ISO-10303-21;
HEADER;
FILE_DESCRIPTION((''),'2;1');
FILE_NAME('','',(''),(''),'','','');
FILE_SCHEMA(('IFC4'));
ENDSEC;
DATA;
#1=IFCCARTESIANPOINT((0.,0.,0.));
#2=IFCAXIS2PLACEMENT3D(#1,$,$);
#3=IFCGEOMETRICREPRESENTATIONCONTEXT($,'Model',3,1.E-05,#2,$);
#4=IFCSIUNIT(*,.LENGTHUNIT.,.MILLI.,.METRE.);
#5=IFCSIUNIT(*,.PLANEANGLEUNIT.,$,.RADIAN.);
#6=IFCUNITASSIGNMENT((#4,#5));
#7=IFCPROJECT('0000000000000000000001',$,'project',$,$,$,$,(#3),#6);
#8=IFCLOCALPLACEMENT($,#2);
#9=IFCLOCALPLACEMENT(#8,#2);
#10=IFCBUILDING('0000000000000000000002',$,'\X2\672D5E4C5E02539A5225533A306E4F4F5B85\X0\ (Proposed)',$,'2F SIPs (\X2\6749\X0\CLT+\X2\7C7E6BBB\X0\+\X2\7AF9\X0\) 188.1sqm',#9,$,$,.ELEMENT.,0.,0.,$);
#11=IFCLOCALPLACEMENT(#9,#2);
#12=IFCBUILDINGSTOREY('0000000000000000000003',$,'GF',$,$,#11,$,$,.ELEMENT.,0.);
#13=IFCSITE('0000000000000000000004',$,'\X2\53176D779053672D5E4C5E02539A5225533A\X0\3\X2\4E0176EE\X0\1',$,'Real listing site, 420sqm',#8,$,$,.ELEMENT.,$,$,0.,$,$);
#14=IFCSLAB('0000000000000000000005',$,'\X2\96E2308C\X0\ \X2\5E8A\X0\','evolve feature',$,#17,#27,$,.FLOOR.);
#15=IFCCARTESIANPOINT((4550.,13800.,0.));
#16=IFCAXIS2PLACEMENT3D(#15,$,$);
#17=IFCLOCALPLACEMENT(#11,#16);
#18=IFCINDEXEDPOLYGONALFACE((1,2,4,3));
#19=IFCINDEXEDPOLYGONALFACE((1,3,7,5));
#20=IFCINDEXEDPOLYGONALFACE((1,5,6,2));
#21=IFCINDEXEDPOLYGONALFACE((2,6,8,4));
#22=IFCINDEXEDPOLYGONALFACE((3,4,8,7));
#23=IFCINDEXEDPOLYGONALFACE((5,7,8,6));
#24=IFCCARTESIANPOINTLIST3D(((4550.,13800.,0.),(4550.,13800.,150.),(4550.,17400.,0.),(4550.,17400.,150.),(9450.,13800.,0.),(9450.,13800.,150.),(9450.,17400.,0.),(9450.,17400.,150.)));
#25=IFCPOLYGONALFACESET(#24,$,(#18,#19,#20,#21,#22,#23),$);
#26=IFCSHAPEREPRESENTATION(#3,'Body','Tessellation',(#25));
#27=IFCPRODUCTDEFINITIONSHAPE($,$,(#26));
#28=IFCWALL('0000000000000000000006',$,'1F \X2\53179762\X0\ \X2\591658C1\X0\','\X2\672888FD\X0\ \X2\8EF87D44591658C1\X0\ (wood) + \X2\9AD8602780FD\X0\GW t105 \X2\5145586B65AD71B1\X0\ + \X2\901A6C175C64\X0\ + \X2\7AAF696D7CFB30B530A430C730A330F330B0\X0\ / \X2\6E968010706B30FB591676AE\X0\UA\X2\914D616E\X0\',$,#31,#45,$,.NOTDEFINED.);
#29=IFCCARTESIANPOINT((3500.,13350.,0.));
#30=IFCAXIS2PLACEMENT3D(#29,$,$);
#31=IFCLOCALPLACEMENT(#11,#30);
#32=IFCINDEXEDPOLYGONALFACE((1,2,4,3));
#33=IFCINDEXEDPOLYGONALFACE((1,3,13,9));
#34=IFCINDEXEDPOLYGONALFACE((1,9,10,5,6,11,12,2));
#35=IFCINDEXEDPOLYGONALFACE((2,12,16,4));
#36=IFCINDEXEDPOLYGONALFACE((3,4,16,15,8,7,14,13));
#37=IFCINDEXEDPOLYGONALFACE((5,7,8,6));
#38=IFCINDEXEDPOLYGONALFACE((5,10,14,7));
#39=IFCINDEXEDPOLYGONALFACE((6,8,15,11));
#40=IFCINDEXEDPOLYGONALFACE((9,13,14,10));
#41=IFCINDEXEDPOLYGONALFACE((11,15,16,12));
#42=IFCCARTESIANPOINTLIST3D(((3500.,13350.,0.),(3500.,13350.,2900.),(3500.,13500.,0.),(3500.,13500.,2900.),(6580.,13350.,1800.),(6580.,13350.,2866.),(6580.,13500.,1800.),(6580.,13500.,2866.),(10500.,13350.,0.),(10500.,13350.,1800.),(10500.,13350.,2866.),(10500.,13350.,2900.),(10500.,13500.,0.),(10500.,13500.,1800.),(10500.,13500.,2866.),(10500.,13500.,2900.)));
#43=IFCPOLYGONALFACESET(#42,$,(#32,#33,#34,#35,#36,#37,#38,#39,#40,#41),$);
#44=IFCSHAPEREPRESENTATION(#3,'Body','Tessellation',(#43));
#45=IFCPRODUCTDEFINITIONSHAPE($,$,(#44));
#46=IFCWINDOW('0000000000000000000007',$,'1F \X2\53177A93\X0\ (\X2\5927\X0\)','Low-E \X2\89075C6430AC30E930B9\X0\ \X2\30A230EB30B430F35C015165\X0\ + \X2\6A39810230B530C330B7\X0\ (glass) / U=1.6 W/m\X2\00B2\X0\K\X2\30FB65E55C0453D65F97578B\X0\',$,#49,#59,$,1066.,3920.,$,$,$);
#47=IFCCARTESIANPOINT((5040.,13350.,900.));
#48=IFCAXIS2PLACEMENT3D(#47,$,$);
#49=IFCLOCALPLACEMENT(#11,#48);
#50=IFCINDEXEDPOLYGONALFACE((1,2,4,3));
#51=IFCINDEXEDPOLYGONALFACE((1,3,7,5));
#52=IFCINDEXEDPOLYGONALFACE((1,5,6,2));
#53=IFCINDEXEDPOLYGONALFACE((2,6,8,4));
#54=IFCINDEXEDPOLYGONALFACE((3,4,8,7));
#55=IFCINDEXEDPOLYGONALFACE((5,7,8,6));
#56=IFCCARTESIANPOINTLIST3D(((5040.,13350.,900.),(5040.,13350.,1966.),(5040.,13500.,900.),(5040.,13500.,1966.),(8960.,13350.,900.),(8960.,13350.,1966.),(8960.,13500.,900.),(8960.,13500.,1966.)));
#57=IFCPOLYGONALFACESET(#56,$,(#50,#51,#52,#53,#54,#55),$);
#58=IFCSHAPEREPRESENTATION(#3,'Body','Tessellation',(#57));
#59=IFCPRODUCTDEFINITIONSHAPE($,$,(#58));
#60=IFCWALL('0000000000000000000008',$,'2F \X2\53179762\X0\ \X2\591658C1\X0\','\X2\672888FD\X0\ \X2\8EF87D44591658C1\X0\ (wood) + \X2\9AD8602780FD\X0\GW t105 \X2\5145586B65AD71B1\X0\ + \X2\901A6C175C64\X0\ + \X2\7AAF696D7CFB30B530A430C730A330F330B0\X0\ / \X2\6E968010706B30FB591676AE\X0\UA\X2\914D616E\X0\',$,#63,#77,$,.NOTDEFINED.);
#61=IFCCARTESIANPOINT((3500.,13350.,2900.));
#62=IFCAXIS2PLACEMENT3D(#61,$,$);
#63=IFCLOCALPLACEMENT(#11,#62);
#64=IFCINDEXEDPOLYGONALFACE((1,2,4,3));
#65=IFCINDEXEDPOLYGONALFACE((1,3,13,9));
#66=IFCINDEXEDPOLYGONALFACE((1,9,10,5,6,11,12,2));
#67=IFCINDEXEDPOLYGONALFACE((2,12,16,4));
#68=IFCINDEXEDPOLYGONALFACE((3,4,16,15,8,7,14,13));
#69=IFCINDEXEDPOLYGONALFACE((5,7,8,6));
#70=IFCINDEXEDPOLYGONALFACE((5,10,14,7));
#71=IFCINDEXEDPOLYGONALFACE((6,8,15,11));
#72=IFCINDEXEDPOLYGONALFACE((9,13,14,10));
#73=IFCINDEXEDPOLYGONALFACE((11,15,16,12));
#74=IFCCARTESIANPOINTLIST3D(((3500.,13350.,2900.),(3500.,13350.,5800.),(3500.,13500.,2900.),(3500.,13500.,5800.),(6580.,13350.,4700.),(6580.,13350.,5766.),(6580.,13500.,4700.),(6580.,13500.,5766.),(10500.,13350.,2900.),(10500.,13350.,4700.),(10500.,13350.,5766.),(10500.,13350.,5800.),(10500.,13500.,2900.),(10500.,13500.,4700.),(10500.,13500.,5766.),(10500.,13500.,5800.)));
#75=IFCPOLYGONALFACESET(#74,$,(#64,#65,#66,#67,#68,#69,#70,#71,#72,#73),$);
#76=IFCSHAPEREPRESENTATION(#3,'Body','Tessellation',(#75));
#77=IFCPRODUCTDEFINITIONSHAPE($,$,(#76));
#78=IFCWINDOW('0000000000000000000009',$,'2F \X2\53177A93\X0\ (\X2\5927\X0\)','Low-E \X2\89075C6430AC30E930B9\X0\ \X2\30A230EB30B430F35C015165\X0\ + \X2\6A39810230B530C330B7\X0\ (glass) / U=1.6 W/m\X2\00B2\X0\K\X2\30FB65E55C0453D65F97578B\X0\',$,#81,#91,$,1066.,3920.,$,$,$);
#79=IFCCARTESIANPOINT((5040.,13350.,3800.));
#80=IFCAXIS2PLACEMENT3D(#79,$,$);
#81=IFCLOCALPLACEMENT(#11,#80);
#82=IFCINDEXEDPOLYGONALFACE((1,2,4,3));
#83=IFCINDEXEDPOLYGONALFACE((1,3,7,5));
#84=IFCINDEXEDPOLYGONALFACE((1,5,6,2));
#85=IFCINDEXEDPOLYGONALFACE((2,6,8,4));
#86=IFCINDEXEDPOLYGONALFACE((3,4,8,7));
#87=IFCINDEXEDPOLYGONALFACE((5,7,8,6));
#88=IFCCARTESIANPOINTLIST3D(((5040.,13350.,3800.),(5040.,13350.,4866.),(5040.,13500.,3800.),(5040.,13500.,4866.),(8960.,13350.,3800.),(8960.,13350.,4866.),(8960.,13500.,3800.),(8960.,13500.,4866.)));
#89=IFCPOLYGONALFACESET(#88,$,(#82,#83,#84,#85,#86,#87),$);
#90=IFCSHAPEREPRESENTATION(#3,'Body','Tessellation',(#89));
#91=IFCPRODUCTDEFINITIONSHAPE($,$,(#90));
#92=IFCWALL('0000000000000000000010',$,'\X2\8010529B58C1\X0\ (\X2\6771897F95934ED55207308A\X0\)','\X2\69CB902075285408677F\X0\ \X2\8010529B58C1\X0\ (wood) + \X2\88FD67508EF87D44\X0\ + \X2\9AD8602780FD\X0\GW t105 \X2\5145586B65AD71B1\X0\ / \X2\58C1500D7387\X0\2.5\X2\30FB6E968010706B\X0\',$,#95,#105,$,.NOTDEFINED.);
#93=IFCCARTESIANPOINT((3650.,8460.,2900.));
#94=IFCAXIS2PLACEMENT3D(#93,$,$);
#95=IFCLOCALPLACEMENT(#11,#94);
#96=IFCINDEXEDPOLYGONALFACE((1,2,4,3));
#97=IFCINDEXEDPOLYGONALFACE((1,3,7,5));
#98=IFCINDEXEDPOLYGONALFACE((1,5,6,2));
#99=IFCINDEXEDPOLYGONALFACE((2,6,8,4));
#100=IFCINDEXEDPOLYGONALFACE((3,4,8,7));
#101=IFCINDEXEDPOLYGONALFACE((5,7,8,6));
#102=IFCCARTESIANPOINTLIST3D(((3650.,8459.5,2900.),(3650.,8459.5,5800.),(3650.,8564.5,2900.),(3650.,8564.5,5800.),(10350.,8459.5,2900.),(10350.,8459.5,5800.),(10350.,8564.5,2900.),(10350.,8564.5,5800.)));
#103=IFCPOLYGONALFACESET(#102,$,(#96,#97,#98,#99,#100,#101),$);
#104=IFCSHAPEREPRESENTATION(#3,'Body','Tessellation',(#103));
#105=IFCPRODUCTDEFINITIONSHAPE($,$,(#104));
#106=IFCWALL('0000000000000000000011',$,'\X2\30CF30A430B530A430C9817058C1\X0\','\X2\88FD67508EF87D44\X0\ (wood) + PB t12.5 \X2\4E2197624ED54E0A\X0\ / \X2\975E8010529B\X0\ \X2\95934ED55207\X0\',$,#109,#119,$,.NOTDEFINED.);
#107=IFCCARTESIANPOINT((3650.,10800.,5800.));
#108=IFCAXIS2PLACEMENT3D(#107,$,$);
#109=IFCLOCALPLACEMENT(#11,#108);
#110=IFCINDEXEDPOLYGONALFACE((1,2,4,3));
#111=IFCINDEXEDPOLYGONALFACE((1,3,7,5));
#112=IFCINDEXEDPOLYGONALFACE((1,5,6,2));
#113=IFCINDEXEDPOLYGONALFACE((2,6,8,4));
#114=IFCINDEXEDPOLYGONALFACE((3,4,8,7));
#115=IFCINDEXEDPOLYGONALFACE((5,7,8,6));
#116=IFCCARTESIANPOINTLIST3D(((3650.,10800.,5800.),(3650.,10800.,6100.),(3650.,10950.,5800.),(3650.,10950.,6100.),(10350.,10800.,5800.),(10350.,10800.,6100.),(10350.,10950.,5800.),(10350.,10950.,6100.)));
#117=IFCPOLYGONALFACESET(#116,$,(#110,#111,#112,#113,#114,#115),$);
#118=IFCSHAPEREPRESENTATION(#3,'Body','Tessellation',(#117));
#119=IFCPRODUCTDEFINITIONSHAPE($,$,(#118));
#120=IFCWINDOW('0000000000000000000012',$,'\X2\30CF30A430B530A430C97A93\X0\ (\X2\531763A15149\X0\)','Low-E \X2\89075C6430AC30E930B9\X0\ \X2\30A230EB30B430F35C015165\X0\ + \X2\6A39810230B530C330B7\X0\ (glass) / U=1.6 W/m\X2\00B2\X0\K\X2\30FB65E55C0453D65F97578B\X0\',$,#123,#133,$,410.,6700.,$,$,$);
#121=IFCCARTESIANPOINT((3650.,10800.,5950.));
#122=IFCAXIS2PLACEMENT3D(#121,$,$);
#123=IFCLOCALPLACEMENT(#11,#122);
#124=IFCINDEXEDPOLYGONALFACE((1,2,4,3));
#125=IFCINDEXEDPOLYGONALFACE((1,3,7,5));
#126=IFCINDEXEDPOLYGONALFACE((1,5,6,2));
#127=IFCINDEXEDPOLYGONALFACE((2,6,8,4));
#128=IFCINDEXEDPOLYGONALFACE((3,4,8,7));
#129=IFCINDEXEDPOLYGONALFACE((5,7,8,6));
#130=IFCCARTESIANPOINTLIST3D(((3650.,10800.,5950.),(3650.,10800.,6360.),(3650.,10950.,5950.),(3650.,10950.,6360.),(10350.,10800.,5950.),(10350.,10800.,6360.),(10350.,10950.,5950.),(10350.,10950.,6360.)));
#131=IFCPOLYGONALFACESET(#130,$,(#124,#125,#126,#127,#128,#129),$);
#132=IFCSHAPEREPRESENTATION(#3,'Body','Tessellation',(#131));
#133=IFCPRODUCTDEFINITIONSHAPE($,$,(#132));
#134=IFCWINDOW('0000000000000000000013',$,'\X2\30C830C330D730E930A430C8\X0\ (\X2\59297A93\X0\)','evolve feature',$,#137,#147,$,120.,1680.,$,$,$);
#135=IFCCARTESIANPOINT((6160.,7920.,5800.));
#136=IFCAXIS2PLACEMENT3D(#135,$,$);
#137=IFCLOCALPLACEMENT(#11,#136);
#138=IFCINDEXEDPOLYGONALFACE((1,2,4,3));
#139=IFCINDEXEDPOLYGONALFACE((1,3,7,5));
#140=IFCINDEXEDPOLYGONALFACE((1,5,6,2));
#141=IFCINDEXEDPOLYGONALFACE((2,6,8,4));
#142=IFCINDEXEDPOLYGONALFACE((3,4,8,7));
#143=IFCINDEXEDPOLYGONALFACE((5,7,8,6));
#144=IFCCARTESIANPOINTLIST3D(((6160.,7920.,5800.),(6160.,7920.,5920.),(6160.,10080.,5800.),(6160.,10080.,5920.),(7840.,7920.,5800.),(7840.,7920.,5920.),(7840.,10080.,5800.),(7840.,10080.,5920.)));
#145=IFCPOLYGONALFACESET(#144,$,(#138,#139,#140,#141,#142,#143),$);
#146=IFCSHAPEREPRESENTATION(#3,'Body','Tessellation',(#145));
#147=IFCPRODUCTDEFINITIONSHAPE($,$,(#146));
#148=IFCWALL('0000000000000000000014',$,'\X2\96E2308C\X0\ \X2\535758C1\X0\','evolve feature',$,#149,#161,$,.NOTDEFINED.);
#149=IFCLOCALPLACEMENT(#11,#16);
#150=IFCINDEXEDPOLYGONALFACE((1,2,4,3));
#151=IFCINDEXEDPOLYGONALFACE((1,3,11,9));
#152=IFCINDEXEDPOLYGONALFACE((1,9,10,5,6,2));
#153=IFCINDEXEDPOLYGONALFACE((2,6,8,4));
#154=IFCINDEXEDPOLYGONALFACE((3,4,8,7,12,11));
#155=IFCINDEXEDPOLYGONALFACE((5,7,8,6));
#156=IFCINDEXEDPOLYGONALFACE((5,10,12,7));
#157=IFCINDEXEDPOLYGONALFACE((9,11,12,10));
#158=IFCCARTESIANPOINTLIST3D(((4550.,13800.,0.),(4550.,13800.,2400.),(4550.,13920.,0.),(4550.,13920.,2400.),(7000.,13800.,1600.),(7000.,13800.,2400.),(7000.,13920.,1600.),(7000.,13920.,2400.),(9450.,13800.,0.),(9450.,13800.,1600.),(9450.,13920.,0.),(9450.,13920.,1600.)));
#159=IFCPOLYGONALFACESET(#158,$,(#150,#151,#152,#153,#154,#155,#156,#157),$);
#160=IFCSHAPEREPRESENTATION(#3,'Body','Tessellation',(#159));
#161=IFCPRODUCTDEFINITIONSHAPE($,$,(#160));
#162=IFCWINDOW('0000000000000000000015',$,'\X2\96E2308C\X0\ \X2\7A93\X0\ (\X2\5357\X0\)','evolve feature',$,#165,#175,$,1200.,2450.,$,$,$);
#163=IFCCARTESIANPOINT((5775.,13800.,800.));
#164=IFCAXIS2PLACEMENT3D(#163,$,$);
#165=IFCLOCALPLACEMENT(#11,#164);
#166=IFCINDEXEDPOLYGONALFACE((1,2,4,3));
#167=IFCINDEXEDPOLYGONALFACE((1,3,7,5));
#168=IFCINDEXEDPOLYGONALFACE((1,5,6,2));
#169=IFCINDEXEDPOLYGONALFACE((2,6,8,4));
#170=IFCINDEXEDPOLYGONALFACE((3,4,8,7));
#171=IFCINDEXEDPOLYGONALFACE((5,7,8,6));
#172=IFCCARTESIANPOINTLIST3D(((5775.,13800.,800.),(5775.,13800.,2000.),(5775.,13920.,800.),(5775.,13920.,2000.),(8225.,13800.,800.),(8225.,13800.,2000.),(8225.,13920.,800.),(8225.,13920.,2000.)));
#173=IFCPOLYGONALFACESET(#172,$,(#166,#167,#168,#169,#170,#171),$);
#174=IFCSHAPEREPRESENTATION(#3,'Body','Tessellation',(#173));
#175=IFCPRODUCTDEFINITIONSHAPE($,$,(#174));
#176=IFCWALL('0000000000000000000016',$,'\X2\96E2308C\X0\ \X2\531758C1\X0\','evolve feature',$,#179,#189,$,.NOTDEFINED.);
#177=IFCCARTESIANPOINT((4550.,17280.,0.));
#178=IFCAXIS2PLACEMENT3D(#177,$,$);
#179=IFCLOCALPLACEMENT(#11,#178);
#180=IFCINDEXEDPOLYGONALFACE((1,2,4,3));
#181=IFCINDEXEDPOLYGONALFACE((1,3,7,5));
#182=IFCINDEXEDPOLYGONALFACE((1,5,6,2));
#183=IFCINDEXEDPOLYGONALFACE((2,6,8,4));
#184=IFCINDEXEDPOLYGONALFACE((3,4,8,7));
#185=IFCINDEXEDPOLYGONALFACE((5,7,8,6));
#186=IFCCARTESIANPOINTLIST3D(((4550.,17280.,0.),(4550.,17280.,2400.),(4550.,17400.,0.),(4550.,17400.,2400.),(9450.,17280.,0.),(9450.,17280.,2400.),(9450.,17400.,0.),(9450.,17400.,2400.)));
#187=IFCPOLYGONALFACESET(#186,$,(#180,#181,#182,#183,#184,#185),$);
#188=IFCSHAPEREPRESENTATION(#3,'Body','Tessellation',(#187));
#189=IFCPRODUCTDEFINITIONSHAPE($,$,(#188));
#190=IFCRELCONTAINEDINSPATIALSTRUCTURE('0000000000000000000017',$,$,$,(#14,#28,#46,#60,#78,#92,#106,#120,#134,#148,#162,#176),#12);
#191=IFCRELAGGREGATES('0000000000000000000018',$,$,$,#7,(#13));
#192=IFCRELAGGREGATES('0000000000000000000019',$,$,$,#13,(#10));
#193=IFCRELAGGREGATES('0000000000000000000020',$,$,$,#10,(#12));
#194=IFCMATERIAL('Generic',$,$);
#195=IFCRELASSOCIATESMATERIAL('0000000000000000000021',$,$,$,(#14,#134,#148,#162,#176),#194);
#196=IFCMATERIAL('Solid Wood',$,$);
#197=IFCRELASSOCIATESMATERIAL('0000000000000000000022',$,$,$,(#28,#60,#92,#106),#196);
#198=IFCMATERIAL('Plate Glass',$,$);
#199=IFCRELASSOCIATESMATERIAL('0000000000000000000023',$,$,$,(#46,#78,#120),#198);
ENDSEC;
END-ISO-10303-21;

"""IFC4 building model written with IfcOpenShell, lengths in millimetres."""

from ifc_helpers import new_model, si_unit, frame, frame_2d, origin, place, context, project, spatial, rectangle, extrude, material, element, fill, save


model = new_model("IFC4")

# Units and contexts
model_context = context("Model", 3, precision=1e-05, world=origin())
ifc_project = project(units=[si_unit("LENGTHUNIT", "METRE", prefix="MILLI"), si_unit("PLANEANGLEUNIT", "RADIAN")], contexts=[model_context])

# Site, building, storey
site_placement = place(None, origin())
site = spatial("IfcSite", under=ifc_project, at=site_placement, Name="北海道札幌市厚別区3丁目1", ObjectType="Real listing site, 420sqm", CompositionType="ELEMENT", RefElevation=0.0)
building_placement = place(site_placement, origin())
building = spatial("IfcBuilding", under=site, at=building_placement, Name="札幌市厚別区の住宅 (Proposed)", ObjectType="2F SIPs (杉CLT+籾殻+竹) 188.1sqm", CompositionType="ELEMENT", ElevationOfRefHeight=0.0, ElevationOfTerrain=0.0)
storey_placement = place(building_placement, origin())
storey = spatial("IfcBuildingStorey", under=building, at=storey_placement, Name="GF", CompositionType="ELEMENT", Elevation=0.0)

# Slab
ifc_material_1 = material(Name="Generic")
slab_placement = place(storey_placement, frame((4550.0, 13800.0, 0.0)))
element("IfcSlab", 1, at=slab_placement, inside=storey, material=ifc_material_1, Name="離れ 床", Description="evolve feature", PredefinedType="FLOOR", context=model_context, shape_type="SweptSolid", body=[
    extrude(rectangle(XDim=4900.0, YDim=3600.0, at=frame_2d((2450.0, 1800.0))), frame((4550.0, 13800.0, 0.0)), (0.0, 0.0, 1.0), 150.0),
])

# Wall, opening, window
ifc_material_2 = material(Name="Solid Wood")
wall_1_placement = place(storey_placement, frame((3500.0, 13350.0, 0.0)))
wall_1 = element("IfcWall", 2, at=wall_1_placement, inside=storey, material=ifc_material_2, Name="1F 北面 外壁", Description="木製 軸組外壁 (wood) + 高性能GW t105 充填断熱 + 通気層 + 窯業系サイディング / 準耐火・外皮UA配慮", PredefinedType="NOTDEFINED", context=model_context, shape_type="SweptSolid", body=[
    extrude(rectangle(XDim=7000.0, YDim=150.0, at=frame_2d((3500.0, 75.0))), frame((3500.0, 13350.0, 0.0)), (0.0, 0.0, 1.0), 2900.0),
])
opening_1_placement = place(storey_placement, frame((5040.0, 13350.0, 900.0)))
opening_1 = element("IfcOpeningElement", 3, at=opening_1_placement, cuts=wall_1, PredefinedType="NOTDEFINED", context=model_context, shape_type="SweptSolid", body=[
    extrude(rectangle(XDim=3920.0, YDim=150.0, at=frame_2d((1960.0, 75.0))), frame((5040.0, 13350.0, 900.0)), (0.0, 0.0, 1.0), 1066.0),
])
ifc_material_3 = material(Name="Plate Glass")
window_1_placement = place(storey_placement, frame((5040.0, 13350.0, 900.0)))
window_1 = element("IfcWindow", 4, at=window_1_placement, inside=storey, material=ifc_material_3, Name="1F 北窓 (大)", Description="Low-E 複層ガラス アルゴン封入 + 樹脂サッシ (glass) / U=1.6 W/m²K・日射取得型", OverallHeight=1066.0, OverallWidth=3920.0, context=model_context, shape_type="SweptSolid", body=[
    extrude(rectangle(XDim=3920.0, YDim=150.0, at=frame_2d((1960.0, 75.0))), frame((5040.0, 13350.0, 900.0)), (0.0, 0.0, 1.0), 1066.0),
])
fill(opening_1, window_1)

# Wall, opening, window
wall_2_placement = place(storey_placement, frame((3500.0, 13350.0, 2900.0)))
wall_2 = element("IfcWall", 5, at=wall_2_placement, inside=storey, material=ifc_material_2, Name="2F 北面 外壁", Description="木製 軸組外壁 (wood) + 高性能GW t105 充填断熱 + 通気層 + 窯業系サイディング / 準耐火・外皮UA配慮", PredefinedType="NOTDEFINED", context=model_context, shape_type="SweptSolid", body=[
    extrude(rectangle(XDim=7000.0, YDim=150.0, at=frame_2d((3500.0, 75.0))), frame((3500.0, 13350.0, 2900.0)), (0.0, 0.0, 1.0), 2900.0),
])
opening_2_placement = place(storey_placement, frame((5040.0, 13350.0, 3800.0)))
opening_2 = element("IfcOpeningElement", 6, at=opening_2_placement, cuts=wall_2, PredefinedType="NOTDEFINED", context=model_context, shape_type="SweptSolid", body=[
    extrude(rectangle(XDim=3920.0, YDim=150.0, at=frame_2d((1960.0, 75.0))), frame((5040.0, 13350.0, 3800.0)), (0.0, 0.0, 1.0), 1066.0),
])
window_2_placement = place(storey_placement, frame((5040.0, 13350.0, 3800.0)))
window_2 = element("IfcWindow", 7, at=window_2_placement, inside=storey, material=ifc_material_3, Name="2F 北窓 (大)", Description="Low-E 複層ガラス アルゴン封入 + 樹脂サッシ (glass) / U=1.6 W/m²K・日射取得型", OverallHeight=1066.0, OverallWidth=3920.0, context=model_context, shape_type="SweptSolid", body=[
    extrude(rectangle(XDim=3920.0, YDim=150.0, at=frame_2d((1960.0, 75.0))), frame((5040.0, 13350.0, 3800.0)), (0.0, 0.0, 1.0), 1066.0),
])
fill(opening_2, window_2)

# Wall
wall_3_placement = place(storey_placement, frame((3650.0, 8460.0, 2900.0)))
element("IfcWall", 8, at=wall_3_placement, inside=storey, material=ifc_material_2, Name="耐力壁 (東西間仕切り)", Description="構造用合板 耐力壁 (wood) + 製材軸組 + 高性能GW t105 充填断熱 / 壁倍率2.5・準耐火", PredefinedType="NOTDEFINED", context=model_context, shape_type="SweptSolid", body=[
    extrude(rectangle(XDim=6700.0, YDim=105.0, at=frame_2d((3350.0, 52.0))), frame((3650.0, 8460.0, 2900.0)), (0.0, 0.0, 1.0), 2900.0),
])

# Wall, opening, window
wall_4_placement = place(storey_placement, frame((3650.0, 10800.0, 5800.0)))
wall_4 = element("IfcWall", 9, at=wall_4_placement, inside=storey, material=ifc_material_2, Name="ハイサイド腰壁", Description="製材軸組 (wood) + PB t12.5 両面仕上 / 非耐力 間仕切", PredefinedType="NOTDEFINED", context=model_context, shape_type="SweptSolid", body=[
    extrude(rectangle(XDim=6700.0, YDim=150.0, at=frame_2d((3350.0, 75.0))), frame((3650.0, 10800.0, 5800.0)), (0.0, 0.0, 1.0), 700.0),
])
opening_3_placement = place(storey_placement, frame((3650.0, 10800.0, 5950.0)))
opening_3 = element("IfcOpeningElement", 10, at=opening_3_placement, cuts=wall_4, PredefinedType="NOTDEFINED", context=model_context, shape_type="SweptSolid", body=[
    extrude(rectangle(XDim=6700.0, YDim=150.0, at=frame_2d((3350.0, 75.0))), frame((3650.0, 10800.0, 5950.0)), (0.0, 0.0, 1.0), 410.0),
])
window_3_placement = place(storey_placement, frame((3650.0, 10800.0, 5950.0)))
window_3 = element("IfcWindow", 11, at=window_3_placement, inside=storey, material=ifc_material_3, Name="ハイサイド窓 (北採光)", Description="Low-E 複層ガラス アルゴン封入 + 樹脂サッシ (glass) / U=1.6 W/m²K・日射取得型", OverallHeight=410.0, OverallWidth=6700.0, context=model_context, shape_type="SweptSolid", body=[
    extrude(rectangle(XDim=6700.0, YDim=150.0, at=frame_2d((3350.0, 75.0))), frame((3650.0, 10800.0, 5950.0)), (0.0, 0.0, 1.0), 410.0),
])
fill(opening_3, window_3)

# Window
window_4_placement = place(storey_placement, frame((6160.0, 7920.0, 5800.0)))
element("IfcWindow", 12, at=window_4_placement, inside=storey, material=ifc_material_1, Name="トップライト (天窓)", Description="evolve feature", OverallHeight=120.0, OverallWidth=1680.0, context=model_context, shape_type="SweptSolid", body=[
    extrude(rectangle(XDim=1680.0, YDim=2160.0, at=frame_2d((840.0, 1080.0))), frame((6160.0, 7920.0, 5800.0)), (0.0, 0.0, 1.0), 120.0),
])

# Wall, opening, window
wall_5_placement = place(storey_placement, frame((4550.0, 13800.0, 0.0)))
wall_5 = element("IfcWall", 13, at=wall_5_placement, inside=storey, material=ifc_material_1, Name="離れ 南壁", Description="evolve feature", PredefinedType="NOTDEFINED", context=model_context, shape_type="SweptSolid", body=[
    extrude(rectangle(XDim=4900.0, YDim=120.0, at=frame_2d((2450.0, 60.0))), frame((4550.0, 13800.0, 0.0)), (0.0, 0.0, 1.0), 2400.0),
])
opening_4_placement = place(storey_placement, frame((5775.0, 13800.0, 800.0)))
opening_4 = element("IfcOpeningElement", 14, at=opening_4_placement, cuts=wall_5, PredefinedType="NOTDEFINED", context=model_context, shape_type="SweptSolid", body=[
    extrude(rectangle(XDim=2450.0, YDim=120.0, at=frame_2d((1225.0, 60.0))), frame((5775.0, 13800.0, 800.0)), (0.0, 0.0, 1.0), 1200.0),
])
window_5_placement = place(storey_placement, frame((5775.0, 13800.0, 800.0)))
window_5 = element("IfcWindow", 15, at=window_5_placement, inside=storey, material=ifc_material_1, Name="離れ 窓 (南)", Description="evolve feature", OverallHeight=1200.0, OverallWidth=2450.0, context=model_context, shape_type="SweptSolid", body=[
    extrude(rectangle(XDim=2450.0, YDim=120.0, at=frame_2d((1225.0, 60.0))), frame((5775.0, 13800.0, 800.0)), (0.0, 0.0, 1.0), 1200.0),
])
fill(opening_4, window_5)

# Wall
wall_6_placement = place(storey_placement, frame((4550.0, 17280.0, 0.0)))
element("IfcWall", 16, at=wall_6_placement, inside=storey, material=ifc_material_1, Name="離れ 北壁", Description="evolve feature", PredefinedType="NOTDEFINED", context=model_context, shape_type="SweptSolid", body=[
    extrude(rectangle(XDim=4900.0, YDim=120.0, at=frame_2d((2450.0, 60.0))), frame((4550.0, 17280.0, 0.0)), (0.0, 0.0, 1.0), 2400.0),
])

save(model, "model.ifc")
